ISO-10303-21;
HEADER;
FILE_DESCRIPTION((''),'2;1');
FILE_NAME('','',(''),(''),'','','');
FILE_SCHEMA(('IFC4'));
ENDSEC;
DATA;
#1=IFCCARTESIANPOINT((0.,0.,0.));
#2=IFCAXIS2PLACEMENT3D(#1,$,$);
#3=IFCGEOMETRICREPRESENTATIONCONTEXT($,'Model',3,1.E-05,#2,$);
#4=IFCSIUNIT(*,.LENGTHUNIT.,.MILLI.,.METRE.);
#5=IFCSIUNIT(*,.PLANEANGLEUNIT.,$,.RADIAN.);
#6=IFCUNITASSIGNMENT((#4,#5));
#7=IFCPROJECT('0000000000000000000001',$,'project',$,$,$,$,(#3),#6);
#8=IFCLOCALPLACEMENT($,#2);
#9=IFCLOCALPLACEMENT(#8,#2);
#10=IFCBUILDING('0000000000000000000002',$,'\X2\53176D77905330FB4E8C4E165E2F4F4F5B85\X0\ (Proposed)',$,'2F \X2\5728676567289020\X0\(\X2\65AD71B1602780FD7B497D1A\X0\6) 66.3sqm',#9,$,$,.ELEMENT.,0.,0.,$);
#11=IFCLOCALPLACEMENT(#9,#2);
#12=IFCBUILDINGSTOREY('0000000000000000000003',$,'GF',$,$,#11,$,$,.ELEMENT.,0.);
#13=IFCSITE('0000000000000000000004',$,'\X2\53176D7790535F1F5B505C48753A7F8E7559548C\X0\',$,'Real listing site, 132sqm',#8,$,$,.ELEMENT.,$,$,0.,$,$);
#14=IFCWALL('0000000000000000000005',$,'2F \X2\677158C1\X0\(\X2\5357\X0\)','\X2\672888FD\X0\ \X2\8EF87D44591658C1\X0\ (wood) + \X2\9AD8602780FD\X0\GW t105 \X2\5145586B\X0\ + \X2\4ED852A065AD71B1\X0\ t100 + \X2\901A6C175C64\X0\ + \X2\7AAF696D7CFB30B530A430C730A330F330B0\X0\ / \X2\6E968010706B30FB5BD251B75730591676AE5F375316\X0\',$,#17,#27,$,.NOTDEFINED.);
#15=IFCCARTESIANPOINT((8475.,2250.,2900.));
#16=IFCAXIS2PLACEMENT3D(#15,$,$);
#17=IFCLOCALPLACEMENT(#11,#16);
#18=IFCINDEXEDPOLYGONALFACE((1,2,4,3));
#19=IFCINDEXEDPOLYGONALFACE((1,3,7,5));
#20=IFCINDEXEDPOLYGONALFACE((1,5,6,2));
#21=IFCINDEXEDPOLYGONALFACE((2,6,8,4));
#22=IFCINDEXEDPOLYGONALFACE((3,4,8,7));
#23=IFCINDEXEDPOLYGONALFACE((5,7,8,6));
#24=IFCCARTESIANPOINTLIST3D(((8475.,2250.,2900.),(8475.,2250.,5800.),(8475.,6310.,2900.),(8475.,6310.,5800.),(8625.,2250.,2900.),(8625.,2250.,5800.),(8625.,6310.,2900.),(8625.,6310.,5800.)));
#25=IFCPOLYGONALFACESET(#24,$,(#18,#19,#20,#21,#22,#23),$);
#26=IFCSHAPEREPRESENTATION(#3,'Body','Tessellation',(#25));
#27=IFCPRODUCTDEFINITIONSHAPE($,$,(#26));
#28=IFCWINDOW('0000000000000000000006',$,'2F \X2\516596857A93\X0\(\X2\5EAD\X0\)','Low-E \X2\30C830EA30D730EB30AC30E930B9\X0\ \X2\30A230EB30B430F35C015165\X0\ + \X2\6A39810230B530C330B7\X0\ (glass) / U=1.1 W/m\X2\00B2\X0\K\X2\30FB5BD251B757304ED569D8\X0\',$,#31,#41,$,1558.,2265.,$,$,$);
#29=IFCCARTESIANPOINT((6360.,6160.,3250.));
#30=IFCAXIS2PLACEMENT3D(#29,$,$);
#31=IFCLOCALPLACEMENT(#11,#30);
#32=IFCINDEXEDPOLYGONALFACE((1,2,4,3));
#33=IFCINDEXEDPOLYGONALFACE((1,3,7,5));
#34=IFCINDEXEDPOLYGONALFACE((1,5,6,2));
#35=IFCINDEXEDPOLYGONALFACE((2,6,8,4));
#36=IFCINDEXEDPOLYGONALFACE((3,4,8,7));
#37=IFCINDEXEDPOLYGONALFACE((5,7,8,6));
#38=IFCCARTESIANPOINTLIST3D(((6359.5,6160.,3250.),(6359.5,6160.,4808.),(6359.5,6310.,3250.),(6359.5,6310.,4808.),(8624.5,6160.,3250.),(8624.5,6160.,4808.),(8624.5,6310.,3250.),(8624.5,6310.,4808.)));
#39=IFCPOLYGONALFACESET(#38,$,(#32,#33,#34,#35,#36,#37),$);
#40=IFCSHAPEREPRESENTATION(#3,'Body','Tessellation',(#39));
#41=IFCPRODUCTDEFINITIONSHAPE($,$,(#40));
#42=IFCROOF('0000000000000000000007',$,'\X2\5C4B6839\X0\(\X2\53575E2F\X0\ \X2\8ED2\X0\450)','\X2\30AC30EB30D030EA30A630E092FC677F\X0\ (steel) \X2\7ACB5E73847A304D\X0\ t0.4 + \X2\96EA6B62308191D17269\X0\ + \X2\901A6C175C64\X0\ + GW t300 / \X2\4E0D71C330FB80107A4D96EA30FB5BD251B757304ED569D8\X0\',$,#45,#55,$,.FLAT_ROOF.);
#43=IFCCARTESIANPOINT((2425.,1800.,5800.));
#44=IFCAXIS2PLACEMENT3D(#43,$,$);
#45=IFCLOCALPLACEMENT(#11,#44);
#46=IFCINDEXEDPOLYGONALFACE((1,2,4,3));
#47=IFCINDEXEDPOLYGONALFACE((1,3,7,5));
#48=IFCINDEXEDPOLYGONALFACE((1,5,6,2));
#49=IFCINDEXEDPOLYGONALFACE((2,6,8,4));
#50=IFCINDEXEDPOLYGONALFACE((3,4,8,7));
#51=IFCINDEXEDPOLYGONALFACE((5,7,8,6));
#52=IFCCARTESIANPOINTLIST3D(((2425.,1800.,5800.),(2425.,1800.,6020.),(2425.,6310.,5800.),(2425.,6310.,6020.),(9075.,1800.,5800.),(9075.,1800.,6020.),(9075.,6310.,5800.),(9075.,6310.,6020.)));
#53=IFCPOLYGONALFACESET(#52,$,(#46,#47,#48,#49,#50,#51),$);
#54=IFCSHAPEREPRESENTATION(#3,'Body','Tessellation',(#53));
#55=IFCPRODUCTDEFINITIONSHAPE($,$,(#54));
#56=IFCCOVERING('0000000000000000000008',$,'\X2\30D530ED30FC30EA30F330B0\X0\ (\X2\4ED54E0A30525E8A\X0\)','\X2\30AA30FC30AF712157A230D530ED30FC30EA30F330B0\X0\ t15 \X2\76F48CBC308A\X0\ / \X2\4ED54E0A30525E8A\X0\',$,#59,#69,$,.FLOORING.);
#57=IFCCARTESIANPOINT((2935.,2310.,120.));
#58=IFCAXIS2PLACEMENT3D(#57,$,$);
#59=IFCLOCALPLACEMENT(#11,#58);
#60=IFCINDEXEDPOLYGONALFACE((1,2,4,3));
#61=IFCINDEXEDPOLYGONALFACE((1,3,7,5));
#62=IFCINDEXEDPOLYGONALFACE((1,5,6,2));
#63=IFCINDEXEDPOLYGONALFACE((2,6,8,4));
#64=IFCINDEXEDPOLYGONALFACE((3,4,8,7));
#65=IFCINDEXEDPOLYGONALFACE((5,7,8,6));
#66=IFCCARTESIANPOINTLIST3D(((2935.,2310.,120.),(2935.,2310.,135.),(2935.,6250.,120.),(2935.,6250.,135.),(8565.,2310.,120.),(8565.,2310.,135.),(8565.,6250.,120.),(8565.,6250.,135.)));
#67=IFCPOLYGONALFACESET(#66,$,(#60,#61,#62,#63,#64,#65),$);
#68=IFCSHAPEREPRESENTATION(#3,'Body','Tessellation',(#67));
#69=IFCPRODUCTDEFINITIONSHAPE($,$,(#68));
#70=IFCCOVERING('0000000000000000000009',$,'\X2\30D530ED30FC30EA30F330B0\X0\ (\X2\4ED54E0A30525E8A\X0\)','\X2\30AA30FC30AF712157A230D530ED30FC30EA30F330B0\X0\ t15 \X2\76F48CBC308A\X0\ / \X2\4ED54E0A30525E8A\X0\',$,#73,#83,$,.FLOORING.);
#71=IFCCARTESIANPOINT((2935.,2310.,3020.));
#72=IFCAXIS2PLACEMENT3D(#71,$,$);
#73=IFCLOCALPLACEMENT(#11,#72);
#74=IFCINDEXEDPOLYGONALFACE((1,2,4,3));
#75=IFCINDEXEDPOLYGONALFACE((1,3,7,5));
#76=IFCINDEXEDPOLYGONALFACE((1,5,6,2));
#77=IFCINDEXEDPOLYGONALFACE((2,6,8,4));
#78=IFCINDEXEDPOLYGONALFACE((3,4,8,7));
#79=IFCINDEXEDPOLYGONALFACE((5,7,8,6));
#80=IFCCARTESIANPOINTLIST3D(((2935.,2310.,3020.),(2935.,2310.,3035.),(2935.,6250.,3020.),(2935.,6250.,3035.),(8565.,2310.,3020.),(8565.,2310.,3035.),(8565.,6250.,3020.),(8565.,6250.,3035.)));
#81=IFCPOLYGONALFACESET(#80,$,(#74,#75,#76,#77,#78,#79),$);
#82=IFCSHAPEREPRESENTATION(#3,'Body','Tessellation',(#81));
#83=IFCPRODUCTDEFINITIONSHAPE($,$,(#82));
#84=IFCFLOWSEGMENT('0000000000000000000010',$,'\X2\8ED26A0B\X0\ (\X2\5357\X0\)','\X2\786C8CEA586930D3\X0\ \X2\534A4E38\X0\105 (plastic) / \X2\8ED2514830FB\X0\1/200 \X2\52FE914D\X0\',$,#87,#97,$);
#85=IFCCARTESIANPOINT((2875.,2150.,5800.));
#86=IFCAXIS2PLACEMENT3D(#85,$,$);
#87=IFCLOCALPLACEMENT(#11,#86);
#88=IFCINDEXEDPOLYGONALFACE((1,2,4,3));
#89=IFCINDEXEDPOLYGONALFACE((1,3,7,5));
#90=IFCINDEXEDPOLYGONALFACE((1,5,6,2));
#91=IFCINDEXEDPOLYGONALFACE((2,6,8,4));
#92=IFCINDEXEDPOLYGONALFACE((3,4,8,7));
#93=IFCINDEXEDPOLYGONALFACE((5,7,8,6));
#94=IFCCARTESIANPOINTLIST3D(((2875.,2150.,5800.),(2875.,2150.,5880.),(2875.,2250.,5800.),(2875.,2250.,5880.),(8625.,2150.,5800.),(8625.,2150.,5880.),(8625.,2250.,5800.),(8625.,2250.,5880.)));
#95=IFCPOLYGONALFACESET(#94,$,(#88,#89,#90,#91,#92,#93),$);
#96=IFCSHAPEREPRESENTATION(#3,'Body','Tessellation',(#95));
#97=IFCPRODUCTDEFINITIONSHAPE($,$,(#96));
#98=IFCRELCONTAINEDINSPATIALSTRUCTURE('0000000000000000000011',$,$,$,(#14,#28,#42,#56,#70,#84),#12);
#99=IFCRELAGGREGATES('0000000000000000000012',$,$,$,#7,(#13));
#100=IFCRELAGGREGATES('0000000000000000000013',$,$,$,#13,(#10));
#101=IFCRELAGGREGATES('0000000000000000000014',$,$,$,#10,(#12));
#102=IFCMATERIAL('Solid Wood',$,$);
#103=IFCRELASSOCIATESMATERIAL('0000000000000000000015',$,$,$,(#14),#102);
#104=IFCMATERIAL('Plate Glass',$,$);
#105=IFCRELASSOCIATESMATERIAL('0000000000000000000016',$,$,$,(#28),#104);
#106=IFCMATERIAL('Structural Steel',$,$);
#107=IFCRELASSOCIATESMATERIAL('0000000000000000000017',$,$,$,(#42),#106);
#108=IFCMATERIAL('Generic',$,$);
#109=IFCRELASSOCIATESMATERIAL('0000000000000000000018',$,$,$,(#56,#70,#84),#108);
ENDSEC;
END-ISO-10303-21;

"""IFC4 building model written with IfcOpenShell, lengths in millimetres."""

from ifc_helpers import new_model, si_unit, frame, frame_2d, origin, place, context, project, spatial, rectangle, extrude, material, element, fill, save


model = new_model("IFC4")

# Units and contexts
model_context = context("Model", 3, precision=1e-05, world=origin())
ifc_project = project(units=[si_unit("LENGTHUNIT", "METRE", prefix="MILLI"), si_unit("PLANEANGLEUNIT", "RADIAN")], contexts=[model_context])

# Site, building, storey
site_placement = place(None, origin())
site = spatial("IfcSite", under=ifc_project, at=site_placement, Name="北海道弟子屈町美留和", ObjectType="Real listing site, 132sqm", CompositionType="ELEMENT", RefElevation=0.0)
building_placement = place(site_placement, origin())
building = spatial("IfcBuilding", under=site, at=building_placement, Name="北海道・二世帯住宅 (Proposed)", ObjectType="2F 在来木造(断熱性能等級6) 66.3sqm", CompositionType="ELEMENT", ElevationOfRefHeight=0.0, ElevationOfTerrain=0.0)
storey_placement = place(building_placement, origin())
storey = spatial("IfcBuildingStorey", under=building, at=storey_placement, Name="GF", CompositionType="ELEMENT", Elevation=0.0)

# Shared definitions
ifc_material_1 = material(Name="Solid Wood")

# Wall, opening, window
ifc_material_2 = material(Name="Plate Glass")
wall_1_placement = place(storey_placement, frame((8475.0, 2250.0, 2900.0)))
wall_1 = element("IfcWall", 1, at=wall_1_placement, inside=storey, material=ifc_material_1, Name="2F 東壁(南)", Description="木製 軸組外壁 (wood) + 高性能GW t105 充填 + 付加断熱 t100 + 通気層 + 窯業系サイディング / 準耐火・寒冷地外皮強化", PredefinedType="NOTDEFINED", context=model_context, shape_type="SweptSolid", body=[
    extrude(rectangle(XDim=150.0, YDim=4060.0, at=frame_2d((75.0, 2030.0))), frame((8475.0, 2250.0, 2900.0)), (0.0, 0.0, 1.0), 2900.0),
])
opening_1_placement = place(storey_placement, frame((6360.0, 6160.0, 3250.0)))
opening_1 = element("IfcOpeningElement", 2, at=opening_1_placement, cuts=wall_1, PredefinedType="NOTDEFINED", context=model_context, shape_type="SweptSolid", body=[
    extrude(rectangle(XDim=2265.0, YDim=150.0, at=frame_2d((1132.0, 75.0))), frame((6360.0, 6160.0, 3250.0)), (0.0, 0.0, 1.0), 1558.0),
])
window_1_placement = place(storey_placement, frame((6360.0, 6160.0, 3250.0)))
window_1 = element("IfcWindow", 3, at=window_1_placement, inside=storey, material=ifc_material_2, Name="2F 入隅窓(庭)", Description="Low-E トリプルガラス アルゴン封入 + 樹脂サッシ (glass) / U=1.1 W/m²K・寒冷地仕様", OverallHeight=1558.0, OverallWidth=2265.0, context=model_context, shape_type="SweptSolid", body=[
    extrude(rectangle(XDim=2265.0, YDim=150.0, at=frame_2d((1132.0, 75.0))), frame((6360.0, 6160.0, 3250.0)), (0.0, 0.0, 1.0), 1558.0),
])
fill(opening_1, window_1)

# Roof
ifc_material_3 = material(Name="Structural Steel")
for number, where, name in (
    (4, (2425.0, 1800.0, 5800.0), "屋根(南帯 軒450)"),
):
    element("IfcRoof", number, at=place(storey_placement, frame(where)), inside=storey, material=ifc_material_3, Name=name, Description="ガルバリウム鋼板 (steel) 立平葺き t0.4 + 雪止め金物 + 通気層 + GW t300 / 不燃・耐積雪・寒冷地仕様", PredefinedType="FLAT_ROOF", context=model_context, shape_type="SweptSolid", body=[
        extrude(rectangle(XDim=6650.0, YDim=4510.0, at=frame_2d((3325.0, 2255.0))), frame((2425.0, 1800.0, 5800.0)), (0.0, 0.0, 1.0), 220.0),
    ])

# Coverings
ifc_material_4 = material(Name="Generic")
covering_1_placement = place(storey_placement, frame((2935.0, 2310.0, 120.0)))
element("IfcCovering", 5, at=covering_1_placement, inside=storey, material=ifc_material_4, Name="フローリング (仕上げ床)", Description="オーク無垢フローリング t15 直貼り / 仕上げ床", PredefinedType="FLOORING", context=model_context, shape_type="SweptSolid", body=[
    extrude(rectangle(XDim=5630.0, YDim=3940.0, at=frame_2d((2815.0, 1970.0))), frame((2935.0, 2310.0, 120.0)), (0.0, 0.0, 1.0), 15.0),
])
covering_2_placement = place(storey_placement, frame((2935.0, 2310.0, 3020.0)))
element("IfcCovering", 6, at=covering_2_placement, inside=storey, material=ifc_material_4, Name="フローリング (仕上げ床)", Description="オーク無垢フローリング t15 直貼り / 仕上げ床", PredefinedType="FLOORING", context=model_context, shape_type="SweptSolid", body=[
    extrude(rectangle(XDim=5630.0, YDim=3940.0, at=frame_2d((2815.0, 1970.0))), frame((2935.0, 2310.0, 3020.0)), (0.0, 0.0, 1.0), 15.0),
])

# Flow segment
flow_segment_placement = place(storey_placement, frame((2875.0, 2150.0, 5800.0)))
element("IfcFlowSegment", 7, at=flow_segment_placement, inside=storey, material=ifc_material_4, Name="軒樋 (南)", Description="硬質塩ビ 半丸105 (plastic) / 軒先・1/200 勾配", context=model_context, shape_type="SweptSolid", body=[
    extrude(rectangle(XDim=5750.0, YDim=100.0, at=frame_2d((2875.0, 50.0))), frame((2875.0, 2150.0, 5800.0)), (0.0, 0.0, 1.0), 80.0),
])

save(model, "model.ifc")
